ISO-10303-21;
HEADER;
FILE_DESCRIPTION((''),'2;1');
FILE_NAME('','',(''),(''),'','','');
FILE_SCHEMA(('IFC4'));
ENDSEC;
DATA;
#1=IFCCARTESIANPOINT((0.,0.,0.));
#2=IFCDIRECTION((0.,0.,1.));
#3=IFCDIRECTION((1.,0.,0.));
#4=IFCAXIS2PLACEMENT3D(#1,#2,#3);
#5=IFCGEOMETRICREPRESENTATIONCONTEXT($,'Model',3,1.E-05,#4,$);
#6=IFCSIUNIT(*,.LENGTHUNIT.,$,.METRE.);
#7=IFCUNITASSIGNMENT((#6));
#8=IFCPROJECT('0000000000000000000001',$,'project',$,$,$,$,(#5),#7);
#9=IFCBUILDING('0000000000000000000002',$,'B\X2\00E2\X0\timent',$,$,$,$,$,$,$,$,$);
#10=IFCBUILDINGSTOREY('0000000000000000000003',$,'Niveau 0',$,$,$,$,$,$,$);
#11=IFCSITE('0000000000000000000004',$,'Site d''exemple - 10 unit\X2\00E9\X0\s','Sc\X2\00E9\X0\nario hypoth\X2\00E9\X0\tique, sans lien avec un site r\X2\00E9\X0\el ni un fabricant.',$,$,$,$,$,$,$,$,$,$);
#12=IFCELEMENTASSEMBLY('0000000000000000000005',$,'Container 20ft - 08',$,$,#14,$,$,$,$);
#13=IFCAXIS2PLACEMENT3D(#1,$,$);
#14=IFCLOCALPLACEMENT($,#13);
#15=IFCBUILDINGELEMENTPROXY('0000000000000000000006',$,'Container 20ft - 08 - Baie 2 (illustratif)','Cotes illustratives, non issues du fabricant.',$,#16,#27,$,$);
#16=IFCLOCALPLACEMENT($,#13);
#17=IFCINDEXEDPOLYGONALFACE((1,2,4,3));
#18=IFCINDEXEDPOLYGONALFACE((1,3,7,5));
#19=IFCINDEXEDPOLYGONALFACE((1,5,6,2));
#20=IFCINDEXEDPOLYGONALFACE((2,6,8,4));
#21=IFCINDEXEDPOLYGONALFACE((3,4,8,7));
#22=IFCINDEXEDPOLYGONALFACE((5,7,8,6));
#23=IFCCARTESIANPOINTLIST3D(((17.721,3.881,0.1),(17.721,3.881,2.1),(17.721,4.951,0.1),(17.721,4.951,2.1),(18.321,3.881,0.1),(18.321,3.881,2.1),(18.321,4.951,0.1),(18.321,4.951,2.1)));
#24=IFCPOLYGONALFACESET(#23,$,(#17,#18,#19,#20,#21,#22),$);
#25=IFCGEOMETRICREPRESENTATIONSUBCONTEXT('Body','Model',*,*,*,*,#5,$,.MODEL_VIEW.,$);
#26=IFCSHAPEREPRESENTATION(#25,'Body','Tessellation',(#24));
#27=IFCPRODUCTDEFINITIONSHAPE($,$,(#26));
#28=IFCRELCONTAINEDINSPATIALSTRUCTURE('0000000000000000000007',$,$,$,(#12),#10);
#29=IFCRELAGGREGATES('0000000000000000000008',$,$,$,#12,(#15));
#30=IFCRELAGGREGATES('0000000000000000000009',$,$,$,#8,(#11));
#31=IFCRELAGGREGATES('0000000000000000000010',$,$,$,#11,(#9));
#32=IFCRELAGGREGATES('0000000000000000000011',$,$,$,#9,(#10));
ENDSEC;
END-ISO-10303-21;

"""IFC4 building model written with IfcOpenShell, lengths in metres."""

from ifc_helpers import new_model, si_unit, frame, origin_with_axes, place, context, subcontext, project, spatial, rectangle, extrude, element, aggregate, save


model = new_model("IFC4")

# Units and contexts
model_context = context("Model", 3, precision=1e-05, world=origin_with_axes())
body_context = subcontext(model_context, "Body", "Model", "MODEL_VIEW")
ifc_project = project(units=[si_unit("LENGTHUNIT", "METRE")], contexts=[model_context])

# Site, building, storey
site = spatial("IfcSite", under=ifc_project, Name="Site d'exemple - 10 unités", Description="Scénario hypothétique, sans lien avec un site réel ni un fabricant.")
building = spatial("IfcBuilding", under=site, Name="Bâtiment")
storey = spatial("IfcBuildingStorey", under=building, Name="Niveau 0")

# Element assembly
assembly_1 = element("IfcElementAssembly", 1, inside=storey, Name="Container 20ft - 08")

# Building element proxy
proxy_1_placement = place(None, frame((18.021, 4.416, 0.1), z_axis=(0.0, 0.0, 1.0), x_axis=(1.0, 0.0, 0.0)))
proxy_1 = element("IfcBuildingElementProxy", 2, at=proxy_1_placement, Name="Container 20ft - 08 - Baie 2 (illustratif)", Description="Cotes illustratives, non issues du fabricant.", context=body_context, shape_type="SweptSolid", body=[
    extrude(rectangle(XDim=0.6, YDim=1.07), origin_with_axes(), (0.0, 0.0, 1.0), 2.0),
])
aggregate(assembly_1, [proxy_1])

save(model, "model.ifc")
